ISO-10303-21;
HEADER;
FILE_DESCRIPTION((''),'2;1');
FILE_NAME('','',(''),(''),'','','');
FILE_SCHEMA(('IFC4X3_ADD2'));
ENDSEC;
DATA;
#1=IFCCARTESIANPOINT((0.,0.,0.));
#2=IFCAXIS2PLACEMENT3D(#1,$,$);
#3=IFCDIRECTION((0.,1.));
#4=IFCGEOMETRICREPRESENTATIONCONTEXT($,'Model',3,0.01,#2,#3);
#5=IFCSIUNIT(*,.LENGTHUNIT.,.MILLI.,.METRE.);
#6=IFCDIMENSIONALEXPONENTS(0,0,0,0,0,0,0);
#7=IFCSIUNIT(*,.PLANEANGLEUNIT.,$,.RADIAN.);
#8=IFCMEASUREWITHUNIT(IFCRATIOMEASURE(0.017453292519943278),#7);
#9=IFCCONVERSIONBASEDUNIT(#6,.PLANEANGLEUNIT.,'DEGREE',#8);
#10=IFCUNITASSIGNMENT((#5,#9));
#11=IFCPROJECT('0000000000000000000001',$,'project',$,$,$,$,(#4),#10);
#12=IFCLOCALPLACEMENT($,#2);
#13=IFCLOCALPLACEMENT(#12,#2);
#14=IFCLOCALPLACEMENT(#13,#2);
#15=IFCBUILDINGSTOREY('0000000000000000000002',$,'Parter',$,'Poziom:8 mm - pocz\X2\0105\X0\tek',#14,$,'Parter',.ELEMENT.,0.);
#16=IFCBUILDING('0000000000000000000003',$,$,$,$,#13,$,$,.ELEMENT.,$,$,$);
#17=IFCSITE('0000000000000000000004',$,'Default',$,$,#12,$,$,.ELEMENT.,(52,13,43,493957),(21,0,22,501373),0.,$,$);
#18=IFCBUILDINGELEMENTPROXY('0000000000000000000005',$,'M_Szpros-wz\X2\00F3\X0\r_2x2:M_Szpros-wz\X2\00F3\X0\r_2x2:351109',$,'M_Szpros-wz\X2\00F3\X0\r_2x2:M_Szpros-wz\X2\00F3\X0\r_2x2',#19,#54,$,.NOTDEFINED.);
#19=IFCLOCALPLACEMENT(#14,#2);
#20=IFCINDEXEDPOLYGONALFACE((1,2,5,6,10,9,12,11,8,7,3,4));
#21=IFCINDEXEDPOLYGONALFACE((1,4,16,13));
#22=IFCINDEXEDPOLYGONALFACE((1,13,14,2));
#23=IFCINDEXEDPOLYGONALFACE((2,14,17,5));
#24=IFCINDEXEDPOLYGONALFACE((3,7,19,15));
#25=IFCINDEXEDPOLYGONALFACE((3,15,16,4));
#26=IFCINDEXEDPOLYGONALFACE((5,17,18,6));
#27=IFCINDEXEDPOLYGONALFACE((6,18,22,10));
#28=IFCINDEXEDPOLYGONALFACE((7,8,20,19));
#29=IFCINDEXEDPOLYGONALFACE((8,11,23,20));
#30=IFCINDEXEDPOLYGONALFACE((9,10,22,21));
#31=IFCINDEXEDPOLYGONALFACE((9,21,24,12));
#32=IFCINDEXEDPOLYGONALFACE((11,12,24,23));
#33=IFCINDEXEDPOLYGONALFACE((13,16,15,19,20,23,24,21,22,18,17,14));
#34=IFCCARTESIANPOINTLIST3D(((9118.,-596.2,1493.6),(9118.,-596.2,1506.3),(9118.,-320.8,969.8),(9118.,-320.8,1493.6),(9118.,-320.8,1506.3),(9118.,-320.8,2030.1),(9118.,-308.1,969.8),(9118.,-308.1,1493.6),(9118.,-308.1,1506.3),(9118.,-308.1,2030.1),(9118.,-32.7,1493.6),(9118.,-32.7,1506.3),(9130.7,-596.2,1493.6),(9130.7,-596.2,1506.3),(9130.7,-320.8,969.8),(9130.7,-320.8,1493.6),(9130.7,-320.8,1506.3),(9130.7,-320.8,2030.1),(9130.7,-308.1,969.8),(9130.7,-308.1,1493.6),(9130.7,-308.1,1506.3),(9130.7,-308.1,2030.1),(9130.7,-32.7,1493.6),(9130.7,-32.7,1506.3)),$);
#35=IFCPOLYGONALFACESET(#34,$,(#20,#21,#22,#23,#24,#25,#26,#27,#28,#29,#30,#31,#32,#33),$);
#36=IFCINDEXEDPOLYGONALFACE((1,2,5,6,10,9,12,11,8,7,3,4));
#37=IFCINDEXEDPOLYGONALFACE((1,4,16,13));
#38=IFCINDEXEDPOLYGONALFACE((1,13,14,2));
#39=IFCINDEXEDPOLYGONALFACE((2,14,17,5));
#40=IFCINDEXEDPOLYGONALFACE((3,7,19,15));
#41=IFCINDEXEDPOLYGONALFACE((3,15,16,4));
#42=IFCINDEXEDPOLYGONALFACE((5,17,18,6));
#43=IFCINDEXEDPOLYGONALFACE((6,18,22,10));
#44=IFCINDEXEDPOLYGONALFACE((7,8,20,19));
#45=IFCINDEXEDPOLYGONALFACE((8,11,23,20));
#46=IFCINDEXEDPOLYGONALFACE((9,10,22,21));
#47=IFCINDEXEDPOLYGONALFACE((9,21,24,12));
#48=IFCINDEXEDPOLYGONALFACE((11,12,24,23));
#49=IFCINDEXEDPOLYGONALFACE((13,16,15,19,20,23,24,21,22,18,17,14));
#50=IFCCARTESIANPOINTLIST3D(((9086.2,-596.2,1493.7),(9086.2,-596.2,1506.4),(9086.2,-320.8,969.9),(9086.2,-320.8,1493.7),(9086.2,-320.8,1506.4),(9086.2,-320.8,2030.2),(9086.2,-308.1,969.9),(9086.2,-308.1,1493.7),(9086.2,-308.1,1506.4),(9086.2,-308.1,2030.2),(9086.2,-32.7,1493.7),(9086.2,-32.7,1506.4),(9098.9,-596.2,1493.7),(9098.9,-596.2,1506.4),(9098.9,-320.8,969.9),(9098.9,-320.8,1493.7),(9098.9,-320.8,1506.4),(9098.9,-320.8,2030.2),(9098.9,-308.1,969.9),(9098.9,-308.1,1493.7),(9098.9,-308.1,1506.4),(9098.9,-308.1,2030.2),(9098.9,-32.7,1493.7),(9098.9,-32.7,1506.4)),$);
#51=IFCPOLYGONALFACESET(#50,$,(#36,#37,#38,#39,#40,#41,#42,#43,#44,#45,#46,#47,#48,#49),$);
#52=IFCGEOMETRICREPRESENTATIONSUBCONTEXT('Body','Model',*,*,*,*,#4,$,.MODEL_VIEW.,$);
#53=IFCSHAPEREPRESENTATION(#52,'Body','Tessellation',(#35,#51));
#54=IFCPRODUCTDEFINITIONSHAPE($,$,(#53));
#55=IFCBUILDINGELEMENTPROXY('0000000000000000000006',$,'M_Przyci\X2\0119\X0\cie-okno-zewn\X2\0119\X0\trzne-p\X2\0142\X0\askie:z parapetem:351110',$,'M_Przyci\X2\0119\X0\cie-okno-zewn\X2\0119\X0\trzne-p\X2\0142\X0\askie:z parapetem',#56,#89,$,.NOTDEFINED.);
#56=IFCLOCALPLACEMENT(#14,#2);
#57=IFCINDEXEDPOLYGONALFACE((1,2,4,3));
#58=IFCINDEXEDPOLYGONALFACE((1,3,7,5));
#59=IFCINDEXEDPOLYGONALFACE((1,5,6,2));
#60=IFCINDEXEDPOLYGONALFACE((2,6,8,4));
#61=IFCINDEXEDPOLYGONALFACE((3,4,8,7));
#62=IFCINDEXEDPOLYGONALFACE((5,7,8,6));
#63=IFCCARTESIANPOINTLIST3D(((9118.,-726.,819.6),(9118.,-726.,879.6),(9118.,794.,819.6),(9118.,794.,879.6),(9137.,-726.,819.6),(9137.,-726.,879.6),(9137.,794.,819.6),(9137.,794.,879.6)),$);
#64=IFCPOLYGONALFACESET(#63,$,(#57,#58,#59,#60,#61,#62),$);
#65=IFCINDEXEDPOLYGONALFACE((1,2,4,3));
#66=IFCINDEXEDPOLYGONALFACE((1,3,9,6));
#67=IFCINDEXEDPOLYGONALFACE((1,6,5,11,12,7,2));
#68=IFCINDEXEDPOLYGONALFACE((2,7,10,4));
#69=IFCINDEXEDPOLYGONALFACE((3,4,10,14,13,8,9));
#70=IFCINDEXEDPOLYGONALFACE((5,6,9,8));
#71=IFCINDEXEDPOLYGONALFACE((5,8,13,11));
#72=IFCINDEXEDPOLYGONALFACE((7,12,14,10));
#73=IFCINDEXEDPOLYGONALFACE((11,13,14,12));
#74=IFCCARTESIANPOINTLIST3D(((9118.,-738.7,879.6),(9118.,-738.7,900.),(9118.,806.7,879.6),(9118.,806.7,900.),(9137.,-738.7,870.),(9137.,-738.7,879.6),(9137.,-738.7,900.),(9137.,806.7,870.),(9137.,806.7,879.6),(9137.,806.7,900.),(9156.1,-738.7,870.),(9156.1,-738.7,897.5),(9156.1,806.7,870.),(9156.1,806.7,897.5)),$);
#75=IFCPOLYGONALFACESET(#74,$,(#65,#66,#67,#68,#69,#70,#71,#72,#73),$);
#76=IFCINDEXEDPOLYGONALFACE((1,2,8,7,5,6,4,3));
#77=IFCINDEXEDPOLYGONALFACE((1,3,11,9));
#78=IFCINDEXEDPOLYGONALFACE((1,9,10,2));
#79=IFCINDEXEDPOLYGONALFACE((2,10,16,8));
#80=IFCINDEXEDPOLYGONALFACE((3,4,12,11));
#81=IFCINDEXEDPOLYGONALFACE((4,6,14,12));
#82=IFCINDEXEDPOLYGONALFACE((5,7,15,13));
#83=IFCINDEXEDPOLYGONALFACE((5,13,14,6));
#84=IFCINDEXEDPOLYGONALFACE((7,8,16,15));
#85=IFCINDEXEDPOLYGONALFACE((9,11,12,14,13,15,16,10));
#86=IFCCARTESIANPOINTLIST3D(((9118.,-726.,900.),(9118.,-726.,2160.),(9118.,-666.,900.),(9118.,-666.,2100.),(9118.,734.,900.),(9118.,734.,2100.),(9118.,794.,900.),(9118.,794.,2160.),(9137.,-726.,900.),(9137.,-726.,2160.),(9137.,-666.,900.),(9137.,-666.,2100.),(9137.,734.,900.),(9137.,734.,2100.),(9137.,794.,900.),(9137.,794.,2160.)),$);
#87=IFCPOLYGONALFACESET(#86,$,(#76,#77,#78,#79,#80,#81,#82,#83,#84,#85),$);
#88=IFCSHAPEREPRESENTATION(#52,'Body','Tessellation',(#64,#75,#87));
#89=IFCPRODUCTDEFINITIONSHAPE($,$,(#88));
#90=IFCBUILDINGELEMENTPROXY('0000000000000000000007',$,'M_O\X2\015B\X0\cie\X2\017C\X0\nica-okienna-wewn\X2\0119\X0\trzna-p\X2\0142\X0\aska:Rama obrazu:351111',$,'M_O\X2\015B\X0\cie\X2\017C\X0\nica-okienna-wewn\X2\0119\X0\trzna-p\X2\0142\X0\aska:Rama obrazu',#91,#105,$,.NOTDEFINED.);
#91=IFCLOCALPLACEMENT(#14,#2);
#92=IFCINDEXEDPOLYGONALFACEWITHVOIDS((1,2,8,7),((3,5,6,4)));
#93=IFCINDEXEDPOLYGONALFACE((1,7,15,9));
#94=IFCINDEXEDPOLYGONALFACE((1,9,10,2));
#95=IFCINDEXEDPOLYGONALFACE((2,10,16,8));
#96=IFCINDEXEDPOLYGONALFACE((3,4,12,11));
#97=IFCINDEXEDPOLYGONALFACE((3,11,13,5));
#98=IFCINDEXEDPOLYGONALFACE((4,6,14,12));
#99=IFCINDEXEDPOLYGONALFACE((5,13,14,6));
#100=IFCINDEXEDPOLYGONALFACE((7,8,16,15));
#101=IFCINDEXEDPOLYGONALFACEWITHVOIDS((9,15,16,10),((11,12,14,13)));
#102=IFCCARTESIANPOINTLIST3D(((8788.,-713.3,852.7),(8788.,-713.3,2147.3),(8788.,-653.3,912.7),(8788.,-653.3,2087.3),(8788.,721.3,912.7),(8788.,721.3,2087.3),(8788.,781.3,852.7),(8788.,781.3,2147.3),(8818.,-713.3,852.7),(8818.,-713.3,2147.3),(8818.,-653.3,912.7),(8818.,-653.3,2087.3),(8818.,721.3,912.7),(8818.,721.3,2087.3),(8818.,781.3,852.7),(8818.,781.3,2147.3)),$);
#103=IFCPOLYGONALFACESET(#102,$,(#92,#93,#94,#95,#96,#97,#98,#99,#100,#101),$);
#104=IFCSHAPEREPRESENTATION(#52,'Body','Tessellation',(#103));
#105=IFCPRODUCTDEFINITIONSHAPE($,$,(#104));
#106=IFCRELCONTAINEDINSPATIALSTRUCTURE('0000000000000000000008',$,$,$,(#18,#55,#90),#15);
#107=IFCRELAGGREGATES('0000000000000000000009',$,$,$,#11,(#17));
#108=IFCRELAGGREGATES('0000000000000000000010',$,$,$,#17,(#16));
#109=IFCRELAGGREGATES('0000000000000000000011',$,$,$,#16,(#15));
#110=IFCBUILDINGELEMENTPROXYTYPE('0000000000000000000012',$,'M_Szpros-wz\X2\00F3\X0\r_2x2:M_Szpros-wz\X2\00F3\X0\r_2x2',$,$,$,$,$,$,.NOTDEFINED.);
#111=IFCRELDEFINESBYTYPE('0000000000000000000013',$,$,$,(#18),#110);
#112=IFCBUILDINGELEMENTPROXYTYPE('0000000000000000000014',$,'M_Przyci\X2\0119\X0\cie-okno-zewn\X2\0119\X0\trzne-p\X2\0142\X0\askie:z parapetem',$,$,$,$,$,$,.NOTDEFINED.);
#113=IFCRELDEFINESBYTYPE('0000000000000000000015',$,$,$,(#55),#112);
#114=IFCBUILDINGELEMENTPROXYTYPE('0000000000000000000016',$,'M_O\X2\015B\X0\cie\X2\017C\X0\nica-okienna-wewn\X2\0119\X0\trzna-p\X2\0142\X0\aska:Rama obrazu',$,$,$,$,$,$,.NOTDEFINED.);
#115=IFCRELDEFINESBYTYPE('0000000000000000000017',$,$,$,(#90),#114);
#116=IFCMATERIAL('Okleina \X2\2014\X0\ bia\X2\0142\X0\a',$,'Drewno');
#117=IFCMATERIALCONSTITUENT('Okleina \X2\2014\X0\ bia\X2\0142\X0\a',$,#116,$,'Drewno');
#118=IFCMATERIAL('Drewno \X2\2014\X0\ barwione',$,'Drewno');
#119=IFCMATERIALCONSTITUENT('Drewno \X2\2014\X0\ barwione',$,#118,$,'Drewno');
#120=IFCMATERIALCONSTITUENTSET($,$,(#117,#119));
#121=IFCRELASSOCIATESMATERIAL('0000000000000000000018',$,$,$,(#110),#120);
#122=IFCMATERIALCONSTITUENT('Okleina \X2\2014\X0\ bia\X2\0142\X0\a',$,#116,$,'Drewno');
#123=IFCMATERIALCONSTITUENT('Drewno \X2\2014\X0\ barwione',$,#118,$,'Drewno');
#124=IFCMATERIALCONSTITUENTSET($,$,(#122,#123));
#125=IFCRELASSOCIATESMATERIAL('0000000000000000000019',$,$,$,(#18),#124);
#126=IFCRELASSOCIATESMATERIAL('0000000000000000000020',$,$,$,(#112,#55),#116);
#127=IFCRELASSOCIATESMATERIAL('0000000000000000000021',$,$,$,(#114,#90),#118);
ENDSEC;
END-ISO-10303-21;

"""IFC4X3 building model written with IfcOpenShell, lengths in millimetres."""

from ifc_helpers import new_model, entity, si_unit, converted_unit, direction, frame, frame_2d, origin, place, context, subcontext, project, spatial, polyline, rectangle, outline, extrude, source, transform, mapped, material, constituent, constituent_set, type_object, type_shapes, element, save


model = new_model("IFC4X3")

# Units and contexts
model_context = context("Model", 3, precision=0.01, world=origin(), true_north=direction((0.0, 1.0)))
body_context = subcontext(model_context, "Body", "Model", "MODEL_VIEW")
ifc_project = project(units=[si_unit("LENGTHUNIT", "METRE", prefix="MILLI"), converted_unit("PLANEANGLEUNIT", "DEGREE", entity("IfcRatioMeasure", 0.017453292519943278), si_unit("PLANEANGLEUNIT", "RADIAN"), dimensions=[0, 0, 0, 0, 0, 0, 0])], contexts=[model_context])

# Site, building, storey
site_placement = place(None, origin())
site = spatial("IfcSite", under=ifc_project, at=site_placement, Name="Default", CompositionType="ELEMENT", RefLatitude=(52, 13, 43, 493957), RefLongitude=(21, 0, 22, 501373), RefElevation=0.0)
building_placement = place(site_placement, origin())
building = spatial("IfcBuilding", under=site, at=building_placement, CompositionType="ELEMENT")
storey_placement = place(building_placement, origin())
storey = spatial("IfcBuildingStorey", under=building, at=storey_placement, Name="Parter", ObjectType="Poziom:8 mm - początek", LongName="Parter", CompositionType="ELEMENT", Elevation=0.0)

# Building element proxies
ifc_material_1 = material(Name="Okleina — biała", Category="Drewno")
ifc_material_2 = material(Name="Drewno — barwione", Category="Drewno")
ifc_constituent_1 = constituent(ifc_material_1, Name="Okleina — biała", Category="Drewno")
ifc_constituent_2 = constituent(ifc_material_2, Name="Drewno — barwione", Category="Drewno")
ifc_constituent_set_1 = constituent_set(constituents=[ifc_constituent_1, ifc_constituent_2])
ifc_constituent_3 = constituent(ifc_material_1, Name="Okleina — biała", Category="Drewno")
ifc_constituent_4 = constituent(ifc_material_2, Name="Drewno — barwione", Category="Drewno")
ifc_constituent_set_2 = constituent_set(constituents=[ifc_constituent_3, ifc_constituent_4])
building_element_proxy_type_1 = type_object("IfcBuildingElementProxyType", Name="M_Szpros-wzór_2x2:M_Szpros-wzór_2x2", PredefinedType="NOTDEFINED", material=ifc_constituent_set_2)
shared_shape_1 = source(origin(), body_context, "Body", "SweptSolid", [
    extrude(outline(polyline([(6.4, -6.4), (530.1, -6.4), (530.1, 6.3), (6.4, 6.3), (6.4, 281.7), (-6.3, 281.7), (-6.3, 6.3), (-530.2, 6.3), (-530.2, -6.4), (-6.3, -6.4), (-6.3, -281.7), (6.4, -281.7), (6.4, -6.4)])), frame((0.0, -22.2, 530.1), z_axis=(0.0, 1.0, 0.0), x_axis=(0.0, 0.0, 1.0)), (0.0, 0.0, 1.0), 12.7),
    extrude(outline(polyline([(6.4, -6.4), (530.2, -6.4), (530.2, 6.3), (6.4, 6.3), (6.4, 281.7), (-6.3, 281.7), (-6.3, 6.3), (-530.2, 6.3), (-530.2, -6.4), (-6.3, -6.4), (-6.3, -281.7), (6.4, -281.7), (6.4, -6.4)])), frame((0.0, 9.5, 530.2), z_axis=(0.0, 1.0, 0.0), x_axis=(0.0, 0.0, 1.0)), (0.0, 0.0, 1.0), 12.7),
])
type_shapes(building_element_proxy_type_1, [shared_shape_1])
proxy_1_placement = place(storey_placement, frame((9108.4, -314.4, 969.9), z_axis=(0.0, 0.0, 1.0), x_axis=(0.0, 1.0, 0.0)))
element("IfcBuildingElementProxy", 1, at=proxy_1_placement, inside=storey, type_object=building_element_proxy_type_1, material=ifc_constituent_set_1, Name="M_Szpros-wzór_2x2:M_Szpros-wzór_2x2:351109", ObjectType="M_Szpros-wzór_2x2:M_Szpros-wzór_2x2", PredefinedType="NOTDEFINED", context=body_context, shape_type="MappedRepresentation", body=[
    mapped(shared_shape_1, transform((0.0, 0.0, 0.0), scale=1.0)),
])
building_element_proxy_type_2 = type_object("IfcBuildingElementProxyType", Name="M_Przycięcie-okno-zewnętrzne-płaskie:z parapetem", PredefinedType="NOTDEFINED", material=ifc_material_1)
shared_shape_2 = source(origin(), body_context, "Body", "SweptSolid", [
    extrude(rectangle(XDim=1520.0, YDim=60.0, at=frame_2d((0.0, 0.0), x_axis=(1.0, 0.0))), frame((0.0, -1250.4, 0.0), z_axis=(0.0, 0.0, 1.0), x_axis=(-1.0, 0.0, 0.0)), (0.0, 0.0, 1.0), 19.0),
    extrude(outline(polyline([(-19.0, -15.2), (0.0, -15.2), (0.0, -5.7), (19.0, -5.7), (19.0, 14.8), (0.0, 14.8), (-19.0, 12.3), (-19.0, -15.2)])), frame((-772.7, -1214.8, 19.0), z_axis=(1.0, 0.0, 0.0), x_axis=(0.0, 0.0, -1.0)), (0.0, 0.0, 1.0), 1545.4),
    extrude(outline(polyline([(-645.0, -760.0), (615.0, -760.0), (615.0, -700.0), (-585.0, -700.0), (-585.0, 700.0), (615.0, 700.0), (615.0, 760.0), (-645.0, 760.0), (-645.0, -760.0)])), frame((0.0, -585.0, 0.0), z_axis=(0.0, 0.0, 1.0), x_axis=(0.0, -1.0, 0.0)), (0.0, 0.0, 1.0), 19.0),
])
type_shapes(building_element_proxy_type_2, [shared_shape_2])
proxy_2_placement = place(storey_placement, frame((9118.0, 34.0, 2100.0), z_axis=(1.0, 0.0, 0.0), x_axis=(0.0, 1.0, 0.0)))
element("IfcBuildingElementProxy", 2, at=proxy_2_placement, inside=storey, type_object=building_element_proxy_type_2, material=ifc_material_1, Name="M_Przycięcie-okno-zewnętrzne-płaskie:z parapetem:351110", ObjectType="M_Przycięcie-okno-zewnętrzne-płaskie:z parapetem", PredefinedType="NOTDEFINED", context=body_context, shape_type="MappedRepresentation", body=[
    mapped(shared_shape_2, transform((0.0, 0.0, 0.0), scale=1.0)),
])
building_element_proxy_type_3 = type_object("IfcBuildingElementProxyType", Name="M_Ościeżnica-okienna-wewnętrzna-płaska:Rama obrazu", PredefinedType="NOTDEFINED", material=ifc_material_2)
shared_shape_3 = source(origin(), body_context, "Body", "SweptSolid", [
    extrude(outline(polyline([(-747.3, -647.3), (747.3, -647.3), (747.3, 647.3), (-747.3, 647.3), (-747.3, -647.3)]), holes=[polyline([(-687.3, -587.3), (-687.3, 587.3), (687.3, 587.3), (687.3, -587.3), (-687.3, -587.3)])]), frame((0.0, -600.0, 0.0), z_axis=(0.0, 0.0, 1.0), x_axis=(-1.0, 0.0, 0.0)), (0.0, 0.0, 1.0), 30.0),
])
type_shapes(building_element_proxy_type_3, [shared_shape_3])
proxy_3_placement = place(storey_placement, frame((8818.0, 34.0, 2100.0), z_axis=(-1.0, 0.0, 0.0), x_axis=(0.0, -1.0, 0.0)))
element("IfcBuildingElementProxy", 3, at=proxy_3_placement, inside=storey, type_object=building_element_proxy_type_3, material=ifc_material_2, Name="M_Ościeżnica-okienna-wewnętrzna-płaska:Rama obrazu:351111", ObjectType="M_Ościeżnica-okienna-wewnętrzna-płaska:Rama obrazu", PredefinedType="NOTDEFINED", context=body_context, shape_type="MappedRepresentation", body=[
    mapped(shared_shape_3, transform((0.0, 0.0, 0.0), scale=1.0)),
])

save(model, "model.ifc")
